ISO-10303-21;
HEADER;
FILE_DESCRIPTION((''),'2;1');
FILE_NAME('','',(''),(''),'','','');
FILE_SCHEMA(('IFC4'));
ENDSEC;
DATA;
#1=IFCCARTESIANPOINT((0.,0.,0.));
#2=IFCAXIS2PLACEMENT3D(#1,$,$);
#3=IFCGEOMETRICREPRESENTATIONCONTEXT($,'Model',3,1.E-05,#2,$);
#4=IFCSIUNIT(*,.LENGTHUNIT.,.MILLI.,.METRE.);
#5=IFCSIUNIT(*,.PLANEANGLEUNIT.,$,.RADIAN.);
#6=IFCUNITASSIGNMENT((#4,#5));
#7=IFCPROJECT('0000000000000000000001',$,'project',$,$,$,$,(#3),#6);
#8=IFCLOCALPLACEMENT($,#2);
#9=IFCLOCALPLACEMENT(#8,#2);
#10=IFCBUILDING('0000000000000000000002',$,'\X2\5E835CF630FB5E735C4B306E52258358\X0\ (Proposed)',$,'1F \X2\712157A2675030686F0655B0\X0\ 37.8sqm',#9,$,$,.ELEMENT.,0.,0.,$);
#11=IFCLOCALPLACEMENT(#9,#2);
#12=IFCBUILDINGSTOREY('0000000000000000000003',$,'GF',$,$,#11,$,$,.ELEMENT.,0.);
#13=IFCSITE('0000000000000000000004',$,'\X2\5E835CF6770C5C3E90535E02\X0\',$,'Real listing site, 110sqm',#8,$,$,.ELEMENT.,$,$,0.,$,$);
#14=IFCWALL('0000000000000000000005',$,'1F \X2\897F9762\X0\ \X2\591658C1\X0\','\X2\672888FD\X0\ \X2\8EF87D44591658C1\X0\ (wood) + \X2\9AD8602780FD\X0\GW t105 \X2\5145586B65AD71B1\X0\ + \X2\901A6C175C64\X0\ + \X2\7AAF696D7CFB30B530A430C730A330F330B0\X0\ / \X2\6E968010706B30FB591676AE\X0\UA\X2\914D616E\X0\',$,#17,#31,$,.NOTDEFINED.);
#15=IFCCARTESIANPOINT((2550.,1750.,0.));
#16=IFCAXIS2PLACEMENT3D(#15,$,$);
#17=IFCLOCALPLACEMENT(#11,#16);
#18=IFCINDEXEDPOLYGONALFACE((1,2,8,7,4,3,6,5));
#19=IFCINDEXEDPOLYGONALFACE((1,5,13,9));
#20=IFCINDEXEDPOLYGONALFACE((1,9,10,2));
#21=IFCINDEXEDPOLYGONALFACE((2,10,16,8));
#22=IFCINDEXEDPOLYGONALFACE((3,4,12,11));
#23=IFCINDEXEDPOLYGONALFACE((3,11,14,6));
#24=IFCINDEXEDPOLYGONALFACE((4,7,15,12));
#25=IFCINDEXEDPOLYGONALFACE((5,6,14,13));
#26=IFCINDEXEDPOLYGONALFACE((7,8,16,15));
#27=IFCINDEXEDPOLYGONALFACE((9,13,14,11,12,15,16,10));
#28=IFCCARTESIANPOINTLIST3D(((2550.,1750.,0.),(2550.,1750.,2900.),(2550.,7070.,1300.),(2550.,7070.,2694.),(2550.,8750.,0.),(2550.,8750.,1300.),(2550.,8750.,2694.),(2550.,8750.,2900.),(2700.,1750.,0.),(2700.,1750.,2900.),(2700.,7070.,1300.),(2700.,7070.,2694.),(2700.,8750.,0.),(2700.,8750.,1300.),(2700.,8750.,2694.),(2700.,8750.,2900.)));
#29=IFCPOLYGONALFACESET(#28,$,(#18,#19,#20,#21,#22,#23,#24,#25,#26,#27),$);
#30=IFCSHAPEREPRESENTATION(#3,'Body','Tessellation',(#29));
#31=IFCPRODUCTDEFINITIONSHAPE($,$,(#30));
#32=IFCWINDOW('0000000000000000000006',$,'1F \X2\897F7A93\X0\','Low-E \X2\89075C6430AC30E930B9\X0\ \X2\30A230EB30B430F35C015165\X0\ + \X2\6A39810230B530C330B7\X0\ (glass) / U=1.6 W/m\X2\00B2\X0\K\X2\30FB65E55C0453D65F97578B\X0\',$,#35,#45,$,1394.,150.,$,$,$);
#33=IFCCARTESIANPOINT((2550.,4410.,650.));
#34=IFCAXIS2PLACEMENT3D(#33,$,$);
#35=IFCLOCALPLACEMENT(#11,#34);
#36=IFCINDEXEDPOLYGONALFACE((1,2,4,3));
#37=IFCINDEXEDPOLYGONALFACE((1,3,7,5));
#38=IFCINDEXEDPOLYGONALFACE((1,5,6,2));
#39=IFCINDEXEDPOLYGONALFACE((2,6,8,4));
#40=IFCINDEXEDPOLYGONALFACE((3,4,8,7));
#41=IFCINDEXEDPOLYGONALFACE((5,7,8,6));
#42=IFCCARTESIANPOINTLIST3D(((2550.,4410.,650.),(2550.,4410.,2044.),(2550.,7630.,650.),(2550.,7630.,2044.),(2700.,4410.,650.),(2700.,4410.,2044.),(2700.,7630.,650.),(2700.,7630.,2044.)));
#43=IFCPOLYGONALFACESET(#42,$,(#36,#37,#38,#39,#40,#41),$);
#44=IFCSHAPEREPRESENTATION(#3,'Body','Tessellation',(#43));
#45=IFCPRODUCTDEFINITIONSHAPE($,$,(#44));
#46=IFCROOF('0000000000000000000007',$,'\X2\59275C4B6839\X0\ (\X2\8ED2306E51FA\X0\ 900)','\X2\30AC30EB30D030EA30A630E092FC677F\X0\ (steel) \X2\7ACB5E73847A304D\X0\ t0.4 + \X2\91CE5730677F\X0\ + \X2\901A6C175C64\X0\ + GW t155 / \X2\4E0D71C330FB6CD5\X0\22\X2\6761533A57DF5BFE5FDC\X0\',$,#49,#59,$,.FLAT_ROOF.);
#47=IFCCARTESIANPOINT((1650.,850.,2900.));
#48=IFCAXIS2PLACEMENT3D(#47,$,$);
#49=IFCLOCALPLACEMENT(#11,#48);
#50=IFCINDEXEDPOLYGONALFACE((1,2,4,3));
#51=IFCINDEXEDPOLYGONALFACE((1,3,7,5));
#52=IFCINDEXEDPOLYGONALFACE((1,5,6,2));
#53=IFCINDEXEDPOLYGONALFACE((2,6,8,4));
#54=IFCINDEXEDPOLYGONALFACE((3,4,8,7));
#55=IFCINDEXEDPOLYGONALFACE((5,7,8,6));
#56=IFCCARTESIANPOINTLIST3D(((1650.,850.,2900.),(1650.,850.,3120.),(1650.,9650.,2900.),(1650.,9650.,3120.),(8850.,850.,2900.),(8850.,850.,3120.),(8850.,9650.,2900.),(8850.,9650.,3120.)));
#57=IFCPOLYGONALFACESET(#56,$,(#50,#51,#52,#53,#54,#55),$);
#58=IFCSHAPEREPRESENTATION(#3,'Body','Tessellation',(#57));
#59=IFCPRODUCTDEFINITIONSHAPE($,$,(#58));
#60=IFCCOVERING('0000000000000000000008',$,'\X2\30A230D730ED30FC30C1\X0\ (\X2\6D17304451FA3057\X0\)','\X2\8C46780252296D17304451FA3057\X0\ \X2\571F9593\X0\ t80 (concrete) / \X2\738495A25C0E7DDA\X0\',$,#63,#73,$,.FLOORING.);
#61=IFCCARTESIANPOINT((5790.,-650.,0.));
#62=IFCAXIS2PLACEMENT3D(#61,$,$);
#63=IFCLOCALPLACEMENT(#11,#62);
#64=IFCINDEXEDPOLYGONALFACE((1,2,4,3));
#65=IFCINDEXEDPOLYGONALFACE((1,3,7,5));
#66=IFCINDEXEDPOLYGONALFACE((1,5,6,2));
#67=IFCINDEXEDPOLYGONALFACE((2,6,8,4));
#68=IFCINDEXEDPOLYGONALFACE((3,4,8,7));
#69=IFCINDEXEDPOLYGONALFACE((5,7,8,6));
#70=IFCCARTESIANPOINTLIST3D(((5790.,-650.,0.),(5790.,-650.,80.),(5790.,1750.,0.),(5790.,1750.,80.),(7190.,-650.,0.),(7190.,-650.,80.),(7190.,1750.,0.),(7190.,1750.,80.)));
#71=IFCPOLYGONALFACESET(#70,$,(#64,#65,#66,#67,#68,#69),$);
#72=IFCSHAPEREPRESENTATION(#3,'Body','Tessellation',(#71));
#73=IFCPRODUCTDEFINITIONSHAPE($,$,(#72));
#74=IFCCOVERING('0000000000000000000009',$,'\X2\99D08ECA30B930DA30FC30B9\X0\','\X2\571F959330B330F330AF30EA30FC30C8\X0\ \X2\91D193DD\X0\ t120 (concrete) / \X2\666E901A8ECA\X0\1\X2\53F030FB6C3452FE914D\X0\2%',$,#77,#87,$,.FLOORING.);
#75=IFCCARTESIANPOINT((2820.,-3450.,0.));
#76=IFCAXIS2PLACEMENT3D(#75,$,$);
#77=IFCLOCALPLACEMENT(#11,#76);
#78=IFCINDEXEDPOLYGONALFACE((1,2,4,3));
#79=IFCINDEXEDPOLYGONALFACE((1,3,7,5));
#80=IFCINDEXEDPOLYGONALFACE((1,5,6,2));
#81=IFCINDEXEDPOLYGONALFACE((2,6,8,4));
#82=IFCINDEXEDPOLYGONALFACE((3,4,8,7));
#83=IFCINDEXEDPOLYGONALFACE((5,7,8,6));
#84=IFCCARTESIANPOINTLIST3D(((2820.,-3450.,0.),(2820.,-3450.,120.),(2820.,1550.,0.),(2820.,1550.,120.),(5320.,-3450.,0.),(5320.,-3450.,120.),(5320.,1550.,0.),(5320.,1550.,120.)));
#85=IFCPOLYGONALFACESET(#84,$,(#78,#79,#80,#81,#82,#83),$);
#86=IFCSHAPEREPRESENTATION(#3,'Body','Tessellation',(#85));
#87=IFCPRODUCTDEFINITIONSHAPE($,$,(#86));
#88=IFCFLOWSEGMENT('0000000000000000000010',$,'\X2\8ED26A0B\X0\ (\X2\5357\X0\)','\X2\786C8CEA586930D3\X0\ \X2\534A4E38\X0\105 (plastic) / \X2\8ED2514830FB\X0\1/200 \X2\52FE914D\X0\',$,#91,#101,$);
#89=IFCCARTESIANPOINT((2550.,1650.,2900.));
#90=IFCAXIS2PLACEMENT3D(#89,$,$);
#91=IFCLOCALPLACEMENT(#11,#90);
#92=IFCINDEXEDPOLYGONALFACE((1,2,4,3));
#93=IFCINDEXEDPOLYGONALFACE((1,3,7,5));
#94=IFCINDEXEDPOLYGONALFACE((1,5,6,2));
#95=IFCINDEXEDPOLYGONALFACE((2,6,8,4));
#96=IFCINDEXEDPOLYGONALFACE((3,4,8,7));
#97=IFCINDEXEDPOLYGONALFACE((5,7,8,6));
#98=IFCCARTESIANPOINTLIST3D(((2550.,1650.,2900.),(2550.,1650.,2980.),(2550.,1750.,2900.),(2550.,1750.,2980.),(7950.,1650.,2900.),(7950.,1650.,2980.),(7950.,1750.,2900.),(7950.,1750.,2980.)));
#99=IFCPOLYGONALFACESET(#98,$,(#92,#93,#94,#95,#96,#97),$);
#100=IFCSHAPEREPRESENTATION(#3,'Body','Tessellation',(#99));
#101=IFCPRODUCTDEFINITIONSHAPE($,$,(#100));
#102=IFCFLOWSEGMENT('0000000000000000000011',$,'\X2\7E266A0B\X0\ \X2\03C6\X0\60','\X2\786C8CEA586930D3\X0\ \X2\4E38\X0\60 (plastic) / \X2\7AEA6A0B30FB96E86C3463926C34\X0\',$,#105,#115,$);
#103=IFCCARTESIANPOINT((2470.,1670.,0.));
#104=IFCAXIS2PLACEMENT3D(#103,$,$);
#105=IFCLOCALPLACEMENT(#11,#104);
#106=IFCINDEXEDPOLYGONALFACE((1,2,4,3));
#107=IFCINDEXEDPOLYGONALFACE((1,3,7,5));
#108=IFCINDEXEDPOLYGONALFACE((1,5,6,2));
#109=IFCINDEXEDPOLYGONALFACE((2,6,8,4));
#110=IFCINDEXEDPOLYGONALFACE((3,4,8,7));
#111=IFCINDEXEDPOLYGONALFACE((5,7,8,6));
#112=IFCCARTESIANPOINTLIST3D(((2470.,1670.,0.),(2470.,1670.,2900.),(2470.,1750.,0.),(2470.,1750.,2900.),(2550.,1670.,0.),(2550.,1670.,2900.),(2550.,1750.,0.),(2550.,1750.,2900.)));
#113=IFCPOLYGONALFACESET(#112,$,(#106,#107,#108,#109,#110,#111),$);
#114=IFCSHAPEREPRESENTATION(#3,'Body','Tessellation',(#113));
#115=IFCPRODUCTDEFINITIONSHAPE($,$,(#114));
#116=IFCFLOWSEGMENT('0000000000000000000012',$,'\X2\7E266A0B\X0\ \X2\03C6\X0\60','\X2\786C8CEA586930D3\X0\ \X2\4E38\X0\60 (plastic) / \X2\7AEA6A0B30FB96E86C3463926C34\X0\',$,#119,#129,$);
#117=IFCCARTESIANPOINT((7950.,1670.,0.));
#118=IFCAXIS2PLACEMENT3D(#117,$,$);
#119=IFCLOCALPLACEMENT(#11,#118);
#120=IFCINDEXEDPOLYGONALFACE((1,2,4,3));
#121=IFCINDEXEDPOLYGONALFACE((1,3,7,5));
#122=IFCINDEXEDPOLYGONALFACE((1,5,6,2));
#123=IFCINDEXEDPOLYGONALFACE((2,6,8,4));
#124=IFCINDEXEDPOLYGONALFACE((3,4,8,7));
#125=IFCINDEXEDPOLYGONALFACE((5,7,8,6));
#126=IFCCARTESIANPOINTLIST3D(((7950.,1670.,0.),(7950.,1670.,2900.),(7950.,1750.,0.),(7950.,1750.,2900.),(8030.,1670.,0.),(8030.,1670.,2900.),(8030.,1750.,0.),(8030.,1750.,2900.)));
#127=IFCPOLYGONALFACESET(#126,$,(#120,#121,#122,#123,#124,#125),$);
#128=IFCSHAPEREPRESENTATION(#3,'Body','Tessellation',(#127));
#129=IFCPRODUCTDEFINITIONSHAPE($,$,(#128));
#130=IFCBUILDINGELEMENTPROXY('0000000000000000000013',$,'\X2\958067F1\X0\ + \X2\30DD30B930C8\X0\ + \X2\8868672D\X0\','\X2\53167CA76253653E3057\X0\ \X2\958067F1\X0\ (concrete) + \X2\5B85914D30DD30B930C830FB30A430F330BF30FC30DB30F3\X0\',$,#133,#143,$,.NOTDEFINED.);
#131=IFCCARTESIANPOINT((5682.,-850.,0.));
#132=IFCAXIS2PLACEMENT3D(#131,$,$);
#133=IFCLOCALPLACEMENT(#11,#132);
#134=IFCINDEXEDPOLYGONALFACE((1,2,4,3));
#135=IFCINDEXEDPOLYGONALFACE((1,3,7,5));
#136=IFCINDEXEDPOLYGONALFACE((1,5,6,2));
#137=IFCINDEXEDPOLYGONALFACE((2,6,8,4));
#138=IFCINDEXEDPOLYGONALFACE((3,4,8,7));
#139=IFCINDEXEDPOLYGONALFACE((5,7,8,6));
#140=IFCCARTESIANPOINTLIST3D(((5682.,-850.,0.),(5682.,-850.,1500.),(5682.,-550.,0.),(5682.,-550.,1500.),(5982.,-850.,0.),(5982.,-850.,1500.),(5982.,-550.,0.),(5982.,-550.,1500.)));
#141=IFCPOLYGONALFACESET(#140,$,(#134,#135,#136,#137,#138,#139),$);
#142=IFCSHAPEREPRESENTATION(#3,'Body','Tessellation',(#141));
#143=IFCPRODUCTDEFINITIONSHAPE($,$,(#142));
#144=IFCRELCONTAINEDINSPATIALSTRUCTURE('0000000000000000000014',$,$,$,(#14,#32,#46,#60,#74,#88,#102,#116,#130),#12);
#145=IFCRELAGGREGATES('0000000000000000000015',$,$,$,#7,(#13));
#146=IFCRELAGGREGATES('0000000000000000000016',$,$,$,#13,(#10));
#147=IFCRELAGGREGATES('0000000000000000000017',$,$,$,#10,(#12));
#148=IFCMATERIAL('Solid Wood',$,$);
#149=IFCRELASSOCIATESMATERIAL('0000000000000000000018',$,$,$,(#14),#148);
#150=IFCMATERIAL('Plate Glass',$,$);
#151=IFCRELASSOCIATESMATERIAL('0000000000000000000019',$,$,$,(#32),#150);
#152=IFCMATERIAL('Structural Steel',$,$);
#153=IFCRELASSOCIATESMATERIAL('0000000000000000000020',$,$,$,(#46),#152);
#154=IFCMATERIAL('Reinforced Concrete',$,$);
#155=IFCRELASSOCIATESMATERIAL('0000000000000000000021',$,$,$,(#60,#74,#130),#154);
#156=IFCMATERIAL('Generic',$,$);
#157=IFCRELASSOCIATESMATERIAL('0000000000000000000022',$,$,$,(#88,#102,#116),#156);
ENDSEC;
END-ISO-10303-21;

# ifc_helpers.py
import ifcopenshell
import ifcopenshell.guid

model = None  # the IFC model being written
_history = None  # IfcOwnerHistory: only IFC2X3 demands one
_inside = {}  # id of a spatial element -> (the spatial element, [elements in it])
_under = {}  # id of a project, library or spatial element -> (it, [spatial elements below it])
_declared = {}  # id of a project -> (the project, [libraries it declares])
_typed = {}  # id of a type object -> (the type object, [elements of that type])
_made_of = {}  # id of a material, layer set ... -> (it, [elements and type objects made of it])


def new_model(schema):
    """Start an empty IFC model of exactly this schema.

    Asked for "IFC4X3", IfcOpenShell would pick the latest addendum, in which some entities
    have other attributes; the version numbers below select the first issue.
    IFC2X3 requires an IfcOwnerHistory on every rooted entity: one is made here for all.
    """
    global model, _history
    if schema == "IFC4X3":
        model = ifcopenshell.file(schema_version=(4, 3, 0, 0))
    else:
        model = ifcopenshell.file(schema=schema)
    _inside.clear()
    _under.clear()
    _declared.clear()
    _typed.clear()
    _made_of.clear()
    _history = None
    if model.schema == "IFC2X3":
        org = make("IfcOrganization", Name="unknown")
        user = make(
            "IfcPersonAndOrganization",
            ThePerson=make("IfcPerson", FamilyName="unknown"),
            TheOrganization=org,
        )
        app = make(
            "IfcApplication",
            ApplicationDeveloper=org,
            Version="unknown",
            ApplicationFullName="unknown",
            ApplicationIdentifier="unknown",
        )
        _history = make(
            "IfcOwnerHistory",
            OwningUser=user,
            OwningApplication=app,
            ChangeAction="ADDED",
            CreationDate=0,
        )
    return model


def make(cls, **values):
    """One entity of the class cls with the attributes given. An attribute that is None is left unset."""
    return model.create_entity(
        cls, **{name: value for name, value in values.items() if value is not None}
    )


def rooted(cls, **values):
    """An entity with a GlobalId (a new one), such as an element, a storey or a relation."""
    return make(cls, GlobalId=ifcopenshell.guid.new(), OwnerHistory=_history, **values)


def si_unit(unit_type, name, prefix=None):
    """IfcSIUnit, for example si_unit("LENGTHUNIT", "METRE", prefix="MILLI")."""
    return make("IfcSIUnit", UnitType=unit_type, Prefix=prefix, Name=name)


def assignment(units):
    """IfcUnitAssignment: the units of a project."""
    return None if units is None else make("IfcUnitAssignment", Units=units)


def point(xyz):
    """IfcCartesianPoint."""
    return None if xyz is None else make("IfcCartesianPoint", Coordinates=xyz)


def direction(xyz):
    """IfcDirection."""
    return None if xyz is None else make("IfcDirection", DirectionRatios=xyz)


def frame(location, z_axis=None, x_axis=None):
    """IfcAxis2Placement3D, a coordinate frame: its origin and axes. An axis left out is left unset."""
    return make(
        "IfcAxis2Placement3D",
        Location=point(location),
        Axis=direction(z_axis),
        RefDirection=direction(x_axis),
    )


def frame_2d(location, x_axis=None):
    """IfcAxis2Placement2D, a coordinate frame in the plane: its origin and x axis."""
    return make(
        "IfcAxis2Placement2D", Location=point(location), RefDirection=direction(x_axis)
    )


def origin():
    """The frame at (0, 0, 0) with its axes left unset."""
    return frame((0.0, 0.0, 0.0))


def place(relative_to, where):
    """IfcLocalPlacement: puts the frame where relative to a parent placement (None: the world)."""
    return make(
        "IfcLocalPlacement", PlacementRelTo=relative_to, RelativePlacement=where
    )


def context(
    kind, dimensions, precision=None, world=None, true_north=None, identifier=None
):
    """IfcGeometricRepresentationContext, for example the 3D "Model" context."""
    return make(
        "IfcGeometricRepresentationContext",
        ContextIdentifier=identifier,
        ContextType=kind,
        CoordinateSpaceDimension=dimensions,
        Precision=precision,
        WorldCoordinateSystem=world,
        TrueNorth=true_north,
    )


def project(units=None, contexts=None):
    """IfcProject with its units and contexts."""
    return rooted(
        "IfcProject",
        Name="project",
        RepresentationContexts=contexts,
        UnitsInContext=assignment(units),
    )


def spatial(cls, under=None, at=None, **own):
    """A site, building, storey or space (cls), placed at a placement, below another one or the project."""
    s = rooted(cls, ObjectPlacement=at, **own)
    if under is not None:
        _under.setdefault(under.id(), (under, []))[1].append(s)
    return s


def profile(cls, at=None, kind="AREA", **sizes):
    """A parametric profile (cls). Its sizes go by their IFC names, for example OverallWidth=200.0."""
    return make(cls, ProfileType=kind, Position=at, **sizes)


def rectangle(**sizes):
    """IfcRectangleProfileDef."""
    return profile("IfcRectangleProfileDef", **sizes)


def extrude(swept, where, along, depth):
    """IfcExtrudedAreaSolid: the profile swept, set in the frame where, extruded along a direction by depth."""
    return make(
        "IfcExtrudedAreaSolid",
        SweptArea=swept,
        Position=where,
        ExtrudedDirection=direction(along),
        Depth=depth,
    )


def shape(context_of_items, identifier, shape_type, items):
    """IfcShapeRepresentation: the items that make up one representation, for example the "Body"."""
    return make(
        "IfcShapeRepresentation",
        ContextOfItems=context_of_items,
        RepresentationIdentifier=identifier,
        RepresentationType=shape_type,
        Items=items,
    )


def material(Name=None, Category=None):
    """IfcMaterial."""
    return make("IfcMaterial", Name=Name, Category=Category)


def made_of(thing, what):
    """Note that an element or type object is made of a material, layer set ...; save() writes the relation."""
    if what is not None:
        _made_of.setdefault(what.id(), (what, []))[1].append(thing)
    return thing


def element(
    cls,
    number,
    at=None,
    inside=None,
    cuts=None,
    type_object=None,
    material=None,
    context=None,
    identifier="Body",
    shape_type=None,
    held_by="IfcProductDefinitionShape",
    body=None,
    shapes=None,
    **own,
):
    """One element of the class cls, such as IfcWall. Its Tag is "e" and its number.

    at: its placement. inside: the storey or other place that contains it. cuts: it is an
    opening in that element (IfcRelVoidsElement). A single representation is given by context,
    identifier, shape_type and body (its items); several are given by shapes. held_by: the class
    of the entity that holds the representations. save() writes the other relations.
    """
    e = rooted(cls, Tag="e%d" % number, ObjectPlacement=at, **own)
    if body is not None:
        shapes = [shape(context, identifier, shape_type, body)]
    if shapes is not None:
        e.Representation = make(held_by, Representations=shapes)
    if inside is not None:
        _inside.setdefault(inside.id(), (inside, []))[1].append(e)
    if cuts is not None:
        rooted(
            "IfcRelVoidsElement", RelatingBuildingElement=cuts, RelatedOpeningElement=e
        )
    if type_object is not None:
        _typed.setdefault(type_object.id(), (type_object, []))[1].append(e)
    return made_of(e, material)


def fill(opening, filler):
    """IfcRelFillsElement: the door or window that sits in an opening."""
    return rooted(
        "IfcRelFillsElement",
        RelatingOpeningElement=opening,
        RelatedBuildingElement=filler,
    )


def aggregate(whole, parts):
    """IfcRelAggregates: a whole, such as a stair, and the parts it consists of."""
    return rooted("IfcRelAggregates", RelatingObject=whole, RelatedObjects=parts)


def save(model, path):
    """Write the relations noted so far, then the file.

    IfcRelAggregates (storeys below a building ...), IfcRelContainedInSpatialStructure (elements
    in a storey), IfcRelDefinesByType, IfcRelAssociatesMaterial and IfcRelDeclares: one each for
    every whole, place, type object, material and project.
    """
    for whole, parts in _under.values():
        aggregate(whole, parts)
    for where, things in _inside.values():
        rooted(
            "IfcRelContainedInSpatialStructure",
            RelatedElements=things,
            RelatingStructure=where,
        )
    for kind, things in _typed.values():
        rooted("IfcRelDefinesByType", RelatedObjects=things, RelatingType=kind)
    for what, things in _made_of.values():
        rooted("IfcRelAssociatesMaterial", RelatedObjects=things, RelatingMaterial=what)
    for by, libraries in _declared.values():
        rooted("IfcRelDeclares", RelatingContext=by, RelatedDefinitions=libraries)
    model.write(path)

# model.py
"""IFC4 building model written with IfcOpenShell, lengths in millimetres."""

from ifc_helpers import new_model, si_unit, frame, frame_2d, origin, place, context, project, spatial, rectangle, extrude, material, element, fill, save


model = new_model("IFC4")

# Units and contexts
model_context = context("Model", 3, precision=1e-05, world=origin())
ifc_project = project(units=[si_unit("LENGTHUNIT", "METRE", prefix="MILLI"), si_unit("PLANEANGLEUNIT", "RADIAN")], contexts=[model_context])

# Site, building, storey
site_placement = place(None, origin())
site = spatial("IfcSite", under=ifc_project, at=site_placement, Name="広島県尾道市", ObjectType="Real listing site, 110sqm", CompositionType="ELEMENT", RefElevation=0.0)
building_placement = place(site_placement, origin())
building = spatial("IfcBuilding", under=site, at=building_placement, Name="広島・平屋の別荘 (Proposed)", ObjectType="1F 無垢材と漆喰 37.8sqm", CompositionType="ELEMENT", ElevationOfRefHeight=0.0, ElevationOfTerrain=0.0)
storey_placement = place(building_placement, origin())
storey = spatial("IfcBuildingStorey", under=building, at=storey_placement, Name="GF", CompositionType="ELEMENT", Elevation=0.0)

# Shared definitions
ifc_material_1 = material(Name="Solid Wood")

# Shared definitions
ifc_material_2 = material(Name="Reinforced Concrete")

# Shared definitions
ifc_material_3 = material(Name="Plate Glass")

# Wall, opening, window
wall_1_placement = place(storey_placement, frame((2550.0, 1750.0, 0.0)))
wall_1 = element("IfcWall", 1, at=wall_1_placement, inside=storey, material=ifc_material_1, Name="1F 西面 外壁", Description="木製 軸組外壁 (wood) + 高性能GW t105 充填断熱 + 通気層 + 窯業系サイディング / 準耐火・外皮UA配慮", PredefinedType="NOTDEFINED", context=model_context, shape_type="SweptSolid", body=[
    extrude(rectangle(XDim=150.0, YDim=7000.0, at=frame_2d((75.0, 3500.0))), frame((2550.0, 1750.0, 0.0)), (0.0, 0.0, 1.0), 2900.0),
])
opening_1_placement = place(storey_placement, frame((2550.0, 4410.0, 650.0)))
opening_1 = element("IfcOpeningElement", 2, at=opening_1_placement, cuts=wall_1, PredefinedType="NOTDEFINED", context=model_context, shape_type="SweptSolid", body=[
    extrude(rectangle(XDim=150.0, YDim=3220.0, at=frame_2d((75.0, 1610.0))), frame((2550.0, 4410.0, 650.0)), (0.0, 0.0, 1.0), 1394.0),
])
window_1_placement = place(storey_placement, frame((2550.0, 4410.0, 650.0)))
window_1 = element("IfcWindow", 3, at=window_1_placement, inside=storey, material=ifc_material_3, Name="1F 西窓", Description="Low-E 複層ガラス アルゴン封入 + 樹脂サッシ (glass) / U=1.6 W/m²K・日射取得型", OverallHeight=1394.0, OverallWidth=150.0, context=model_context, shape_type="SweptSolid", body=[
    extrude(rectangle(XDim=150.0, YDim=3220.0, at=frame_2d((75.0, 1610.0))), frame((2550.0, 4410.0, 650.0)), (0.0, 0.0, 1.0), 1394.0),
])
fill(opening_1, window_1)

# Roof
ifc_material_4 = material(Name="Structural Steel")
roof_placement = place(storey_placement, frame((1650.0, 850.0, 2900.0)))
element("IfcRoof", 4, at=roof_placement, inside=storey, material=ifc_material_4, Name="大屋根 (軒の出 900)", Description="ガルバリウム鋼板 (steel) 立平葺き t0.4 + 野地板 + 通気層 + GW t155 / 不燃・法22条区域対応", PredefinedType="FLAT_ROOF", context=model_context, shape_type="SweptSolid", body=[
    extrude(rectangle(XDim=7200.0, YDim=8800.0, at=frame_2d((3600.0, 4400.0))), frame((1650.0, 850.0, 2900.0)), (0.0, 0.0, 1.0), 220.0),
])

# Coverings
covering_1_placement = place(storey_placement, frame((5790.0, -650.0, 0.0)))
element("IfcCovering", 5, at=covering_1_placement, inside=storey, material=ifc_material_2, Name="アプローチ (洗い出し)", Description="豆砂利洗い出し 土間 t80 (concrete) / 玄関導線", PredefinedType="FLOORING", context=model_context, shape_type="SweptSolid", body=[
    extrude(rectangle(XDim=1400.0, YDim=2400.0, at=frame_2d((700.0, 1200.0))), frame((5790.0, -650.0, 0.0)), (0.0, 0.0, 1.0), 80.0),
])
covering_2_placement = place(storey_placement, frame((2820.0, -3450.0, 0.0)))
element("IfcCovering", 6, at=covering_2_placement, inside=storey, material=ifc_material_2, Name="駐車スペース", Description="土間コンクリート 金鏝 t120 (concrete) / 普通車1台・水勾配2%", PredefinedType="FLOORING", context=model_context, shape_type="SweptSolid", body=[
    extrude(rectangle(XDim=2500.0, YDim=5000.0, at=frame_2d((1250.0, 2500.0))), frame((2820.0, -3450.0, 0.0)), (0.0, 0.0, 1.0), 120.0),
])

# Flow segments
ifc_material_5 = material(Name="Generic")
flow_segment_1_placement = place(storey_placement, frame((2550.0, 1650.0, 2900.0)))
element("IfcFlowSegment", 7, at=flow_segment_1_placement, inside=storey, material=ifc_material_5, Name="軒樋 (南)", Description="硬質塩ビ 半丸105 (plastic) / 軒先・1/200 勾配", context=model_context, shape_type="SweptSolid", body=[
    extrude(rectangle(XDim=5400.0, YDim=100.0, at=frame_2d((2700.0, 50.0))), frame((2550.0, 1650.0, 2900.0)), (0.0, 0.0, 1.0), 80.0),
])
flow_segment_2_placement = place(storey_placement, frame((2470.0, 1670.0, 0.0)))
element("IfcFlowSegment", 8, at=flow_segment_2_placement, inside=storey, material=ifc_material_5, Name="縦樋 φ60", Description="硬質塩ビ 丸60 (plastic) / 竪樋・雨水排水", context=model_context, shape_type="SweptSolid", body=[
    extrude(rectangle(XDim=80.0, YDim=80.0, at=frame_2d((40.0, 40.0))), frame((2470.0, 1670.0, 0.0)), (0.0, 0.0, 1.0), 2900.0),
])
flow_segment_3_placement = place(storey_placement, frame((7950.0, 1670.0, 0.0)))
element("IfcFlowSegment", 9, at=flow_segment_3_placement, inside=storey, material=ifc_material_5, Name="縦樋 φ60", Description="硬質塩ビ 丸60 (plastic) / 竪樋・雨水排水", context=model_context, shape_type="SweptSolid", body=[
    extrude(rectangle(XDim=80.0, YDim=80.0, at=frame_2d((40.0, 40.0))), frame((7950.0, 1670.0, 0.0)), (0.0, 0.0, 1.0), 2900.0),
])

# Building element proxy
proxy_placement = place(storey_placement, frame((5682.0, -850.0, 0.0)))
element("IfcBuildingElementProxy", 10, at=proxy_placement, inside=storey, material=ifc_material_2, Name="門柱 + ポスト + 表札", Description="化粧打放し 門柱 (concrete) + 宅配ポスト・インターホン", PredefinedType="NOTDEFINED", context=model_context, shape_type="SweptSolid", body=[
    extrude(rectangle(XDim=300.0, YDim=300.0, at=frame_2d((150.0, 150.0))), frame((5682.0, -850.0, 0.0)), (0.0, 0.0, 1.0), 1500.0),
])

save(model, "model.ifc")
